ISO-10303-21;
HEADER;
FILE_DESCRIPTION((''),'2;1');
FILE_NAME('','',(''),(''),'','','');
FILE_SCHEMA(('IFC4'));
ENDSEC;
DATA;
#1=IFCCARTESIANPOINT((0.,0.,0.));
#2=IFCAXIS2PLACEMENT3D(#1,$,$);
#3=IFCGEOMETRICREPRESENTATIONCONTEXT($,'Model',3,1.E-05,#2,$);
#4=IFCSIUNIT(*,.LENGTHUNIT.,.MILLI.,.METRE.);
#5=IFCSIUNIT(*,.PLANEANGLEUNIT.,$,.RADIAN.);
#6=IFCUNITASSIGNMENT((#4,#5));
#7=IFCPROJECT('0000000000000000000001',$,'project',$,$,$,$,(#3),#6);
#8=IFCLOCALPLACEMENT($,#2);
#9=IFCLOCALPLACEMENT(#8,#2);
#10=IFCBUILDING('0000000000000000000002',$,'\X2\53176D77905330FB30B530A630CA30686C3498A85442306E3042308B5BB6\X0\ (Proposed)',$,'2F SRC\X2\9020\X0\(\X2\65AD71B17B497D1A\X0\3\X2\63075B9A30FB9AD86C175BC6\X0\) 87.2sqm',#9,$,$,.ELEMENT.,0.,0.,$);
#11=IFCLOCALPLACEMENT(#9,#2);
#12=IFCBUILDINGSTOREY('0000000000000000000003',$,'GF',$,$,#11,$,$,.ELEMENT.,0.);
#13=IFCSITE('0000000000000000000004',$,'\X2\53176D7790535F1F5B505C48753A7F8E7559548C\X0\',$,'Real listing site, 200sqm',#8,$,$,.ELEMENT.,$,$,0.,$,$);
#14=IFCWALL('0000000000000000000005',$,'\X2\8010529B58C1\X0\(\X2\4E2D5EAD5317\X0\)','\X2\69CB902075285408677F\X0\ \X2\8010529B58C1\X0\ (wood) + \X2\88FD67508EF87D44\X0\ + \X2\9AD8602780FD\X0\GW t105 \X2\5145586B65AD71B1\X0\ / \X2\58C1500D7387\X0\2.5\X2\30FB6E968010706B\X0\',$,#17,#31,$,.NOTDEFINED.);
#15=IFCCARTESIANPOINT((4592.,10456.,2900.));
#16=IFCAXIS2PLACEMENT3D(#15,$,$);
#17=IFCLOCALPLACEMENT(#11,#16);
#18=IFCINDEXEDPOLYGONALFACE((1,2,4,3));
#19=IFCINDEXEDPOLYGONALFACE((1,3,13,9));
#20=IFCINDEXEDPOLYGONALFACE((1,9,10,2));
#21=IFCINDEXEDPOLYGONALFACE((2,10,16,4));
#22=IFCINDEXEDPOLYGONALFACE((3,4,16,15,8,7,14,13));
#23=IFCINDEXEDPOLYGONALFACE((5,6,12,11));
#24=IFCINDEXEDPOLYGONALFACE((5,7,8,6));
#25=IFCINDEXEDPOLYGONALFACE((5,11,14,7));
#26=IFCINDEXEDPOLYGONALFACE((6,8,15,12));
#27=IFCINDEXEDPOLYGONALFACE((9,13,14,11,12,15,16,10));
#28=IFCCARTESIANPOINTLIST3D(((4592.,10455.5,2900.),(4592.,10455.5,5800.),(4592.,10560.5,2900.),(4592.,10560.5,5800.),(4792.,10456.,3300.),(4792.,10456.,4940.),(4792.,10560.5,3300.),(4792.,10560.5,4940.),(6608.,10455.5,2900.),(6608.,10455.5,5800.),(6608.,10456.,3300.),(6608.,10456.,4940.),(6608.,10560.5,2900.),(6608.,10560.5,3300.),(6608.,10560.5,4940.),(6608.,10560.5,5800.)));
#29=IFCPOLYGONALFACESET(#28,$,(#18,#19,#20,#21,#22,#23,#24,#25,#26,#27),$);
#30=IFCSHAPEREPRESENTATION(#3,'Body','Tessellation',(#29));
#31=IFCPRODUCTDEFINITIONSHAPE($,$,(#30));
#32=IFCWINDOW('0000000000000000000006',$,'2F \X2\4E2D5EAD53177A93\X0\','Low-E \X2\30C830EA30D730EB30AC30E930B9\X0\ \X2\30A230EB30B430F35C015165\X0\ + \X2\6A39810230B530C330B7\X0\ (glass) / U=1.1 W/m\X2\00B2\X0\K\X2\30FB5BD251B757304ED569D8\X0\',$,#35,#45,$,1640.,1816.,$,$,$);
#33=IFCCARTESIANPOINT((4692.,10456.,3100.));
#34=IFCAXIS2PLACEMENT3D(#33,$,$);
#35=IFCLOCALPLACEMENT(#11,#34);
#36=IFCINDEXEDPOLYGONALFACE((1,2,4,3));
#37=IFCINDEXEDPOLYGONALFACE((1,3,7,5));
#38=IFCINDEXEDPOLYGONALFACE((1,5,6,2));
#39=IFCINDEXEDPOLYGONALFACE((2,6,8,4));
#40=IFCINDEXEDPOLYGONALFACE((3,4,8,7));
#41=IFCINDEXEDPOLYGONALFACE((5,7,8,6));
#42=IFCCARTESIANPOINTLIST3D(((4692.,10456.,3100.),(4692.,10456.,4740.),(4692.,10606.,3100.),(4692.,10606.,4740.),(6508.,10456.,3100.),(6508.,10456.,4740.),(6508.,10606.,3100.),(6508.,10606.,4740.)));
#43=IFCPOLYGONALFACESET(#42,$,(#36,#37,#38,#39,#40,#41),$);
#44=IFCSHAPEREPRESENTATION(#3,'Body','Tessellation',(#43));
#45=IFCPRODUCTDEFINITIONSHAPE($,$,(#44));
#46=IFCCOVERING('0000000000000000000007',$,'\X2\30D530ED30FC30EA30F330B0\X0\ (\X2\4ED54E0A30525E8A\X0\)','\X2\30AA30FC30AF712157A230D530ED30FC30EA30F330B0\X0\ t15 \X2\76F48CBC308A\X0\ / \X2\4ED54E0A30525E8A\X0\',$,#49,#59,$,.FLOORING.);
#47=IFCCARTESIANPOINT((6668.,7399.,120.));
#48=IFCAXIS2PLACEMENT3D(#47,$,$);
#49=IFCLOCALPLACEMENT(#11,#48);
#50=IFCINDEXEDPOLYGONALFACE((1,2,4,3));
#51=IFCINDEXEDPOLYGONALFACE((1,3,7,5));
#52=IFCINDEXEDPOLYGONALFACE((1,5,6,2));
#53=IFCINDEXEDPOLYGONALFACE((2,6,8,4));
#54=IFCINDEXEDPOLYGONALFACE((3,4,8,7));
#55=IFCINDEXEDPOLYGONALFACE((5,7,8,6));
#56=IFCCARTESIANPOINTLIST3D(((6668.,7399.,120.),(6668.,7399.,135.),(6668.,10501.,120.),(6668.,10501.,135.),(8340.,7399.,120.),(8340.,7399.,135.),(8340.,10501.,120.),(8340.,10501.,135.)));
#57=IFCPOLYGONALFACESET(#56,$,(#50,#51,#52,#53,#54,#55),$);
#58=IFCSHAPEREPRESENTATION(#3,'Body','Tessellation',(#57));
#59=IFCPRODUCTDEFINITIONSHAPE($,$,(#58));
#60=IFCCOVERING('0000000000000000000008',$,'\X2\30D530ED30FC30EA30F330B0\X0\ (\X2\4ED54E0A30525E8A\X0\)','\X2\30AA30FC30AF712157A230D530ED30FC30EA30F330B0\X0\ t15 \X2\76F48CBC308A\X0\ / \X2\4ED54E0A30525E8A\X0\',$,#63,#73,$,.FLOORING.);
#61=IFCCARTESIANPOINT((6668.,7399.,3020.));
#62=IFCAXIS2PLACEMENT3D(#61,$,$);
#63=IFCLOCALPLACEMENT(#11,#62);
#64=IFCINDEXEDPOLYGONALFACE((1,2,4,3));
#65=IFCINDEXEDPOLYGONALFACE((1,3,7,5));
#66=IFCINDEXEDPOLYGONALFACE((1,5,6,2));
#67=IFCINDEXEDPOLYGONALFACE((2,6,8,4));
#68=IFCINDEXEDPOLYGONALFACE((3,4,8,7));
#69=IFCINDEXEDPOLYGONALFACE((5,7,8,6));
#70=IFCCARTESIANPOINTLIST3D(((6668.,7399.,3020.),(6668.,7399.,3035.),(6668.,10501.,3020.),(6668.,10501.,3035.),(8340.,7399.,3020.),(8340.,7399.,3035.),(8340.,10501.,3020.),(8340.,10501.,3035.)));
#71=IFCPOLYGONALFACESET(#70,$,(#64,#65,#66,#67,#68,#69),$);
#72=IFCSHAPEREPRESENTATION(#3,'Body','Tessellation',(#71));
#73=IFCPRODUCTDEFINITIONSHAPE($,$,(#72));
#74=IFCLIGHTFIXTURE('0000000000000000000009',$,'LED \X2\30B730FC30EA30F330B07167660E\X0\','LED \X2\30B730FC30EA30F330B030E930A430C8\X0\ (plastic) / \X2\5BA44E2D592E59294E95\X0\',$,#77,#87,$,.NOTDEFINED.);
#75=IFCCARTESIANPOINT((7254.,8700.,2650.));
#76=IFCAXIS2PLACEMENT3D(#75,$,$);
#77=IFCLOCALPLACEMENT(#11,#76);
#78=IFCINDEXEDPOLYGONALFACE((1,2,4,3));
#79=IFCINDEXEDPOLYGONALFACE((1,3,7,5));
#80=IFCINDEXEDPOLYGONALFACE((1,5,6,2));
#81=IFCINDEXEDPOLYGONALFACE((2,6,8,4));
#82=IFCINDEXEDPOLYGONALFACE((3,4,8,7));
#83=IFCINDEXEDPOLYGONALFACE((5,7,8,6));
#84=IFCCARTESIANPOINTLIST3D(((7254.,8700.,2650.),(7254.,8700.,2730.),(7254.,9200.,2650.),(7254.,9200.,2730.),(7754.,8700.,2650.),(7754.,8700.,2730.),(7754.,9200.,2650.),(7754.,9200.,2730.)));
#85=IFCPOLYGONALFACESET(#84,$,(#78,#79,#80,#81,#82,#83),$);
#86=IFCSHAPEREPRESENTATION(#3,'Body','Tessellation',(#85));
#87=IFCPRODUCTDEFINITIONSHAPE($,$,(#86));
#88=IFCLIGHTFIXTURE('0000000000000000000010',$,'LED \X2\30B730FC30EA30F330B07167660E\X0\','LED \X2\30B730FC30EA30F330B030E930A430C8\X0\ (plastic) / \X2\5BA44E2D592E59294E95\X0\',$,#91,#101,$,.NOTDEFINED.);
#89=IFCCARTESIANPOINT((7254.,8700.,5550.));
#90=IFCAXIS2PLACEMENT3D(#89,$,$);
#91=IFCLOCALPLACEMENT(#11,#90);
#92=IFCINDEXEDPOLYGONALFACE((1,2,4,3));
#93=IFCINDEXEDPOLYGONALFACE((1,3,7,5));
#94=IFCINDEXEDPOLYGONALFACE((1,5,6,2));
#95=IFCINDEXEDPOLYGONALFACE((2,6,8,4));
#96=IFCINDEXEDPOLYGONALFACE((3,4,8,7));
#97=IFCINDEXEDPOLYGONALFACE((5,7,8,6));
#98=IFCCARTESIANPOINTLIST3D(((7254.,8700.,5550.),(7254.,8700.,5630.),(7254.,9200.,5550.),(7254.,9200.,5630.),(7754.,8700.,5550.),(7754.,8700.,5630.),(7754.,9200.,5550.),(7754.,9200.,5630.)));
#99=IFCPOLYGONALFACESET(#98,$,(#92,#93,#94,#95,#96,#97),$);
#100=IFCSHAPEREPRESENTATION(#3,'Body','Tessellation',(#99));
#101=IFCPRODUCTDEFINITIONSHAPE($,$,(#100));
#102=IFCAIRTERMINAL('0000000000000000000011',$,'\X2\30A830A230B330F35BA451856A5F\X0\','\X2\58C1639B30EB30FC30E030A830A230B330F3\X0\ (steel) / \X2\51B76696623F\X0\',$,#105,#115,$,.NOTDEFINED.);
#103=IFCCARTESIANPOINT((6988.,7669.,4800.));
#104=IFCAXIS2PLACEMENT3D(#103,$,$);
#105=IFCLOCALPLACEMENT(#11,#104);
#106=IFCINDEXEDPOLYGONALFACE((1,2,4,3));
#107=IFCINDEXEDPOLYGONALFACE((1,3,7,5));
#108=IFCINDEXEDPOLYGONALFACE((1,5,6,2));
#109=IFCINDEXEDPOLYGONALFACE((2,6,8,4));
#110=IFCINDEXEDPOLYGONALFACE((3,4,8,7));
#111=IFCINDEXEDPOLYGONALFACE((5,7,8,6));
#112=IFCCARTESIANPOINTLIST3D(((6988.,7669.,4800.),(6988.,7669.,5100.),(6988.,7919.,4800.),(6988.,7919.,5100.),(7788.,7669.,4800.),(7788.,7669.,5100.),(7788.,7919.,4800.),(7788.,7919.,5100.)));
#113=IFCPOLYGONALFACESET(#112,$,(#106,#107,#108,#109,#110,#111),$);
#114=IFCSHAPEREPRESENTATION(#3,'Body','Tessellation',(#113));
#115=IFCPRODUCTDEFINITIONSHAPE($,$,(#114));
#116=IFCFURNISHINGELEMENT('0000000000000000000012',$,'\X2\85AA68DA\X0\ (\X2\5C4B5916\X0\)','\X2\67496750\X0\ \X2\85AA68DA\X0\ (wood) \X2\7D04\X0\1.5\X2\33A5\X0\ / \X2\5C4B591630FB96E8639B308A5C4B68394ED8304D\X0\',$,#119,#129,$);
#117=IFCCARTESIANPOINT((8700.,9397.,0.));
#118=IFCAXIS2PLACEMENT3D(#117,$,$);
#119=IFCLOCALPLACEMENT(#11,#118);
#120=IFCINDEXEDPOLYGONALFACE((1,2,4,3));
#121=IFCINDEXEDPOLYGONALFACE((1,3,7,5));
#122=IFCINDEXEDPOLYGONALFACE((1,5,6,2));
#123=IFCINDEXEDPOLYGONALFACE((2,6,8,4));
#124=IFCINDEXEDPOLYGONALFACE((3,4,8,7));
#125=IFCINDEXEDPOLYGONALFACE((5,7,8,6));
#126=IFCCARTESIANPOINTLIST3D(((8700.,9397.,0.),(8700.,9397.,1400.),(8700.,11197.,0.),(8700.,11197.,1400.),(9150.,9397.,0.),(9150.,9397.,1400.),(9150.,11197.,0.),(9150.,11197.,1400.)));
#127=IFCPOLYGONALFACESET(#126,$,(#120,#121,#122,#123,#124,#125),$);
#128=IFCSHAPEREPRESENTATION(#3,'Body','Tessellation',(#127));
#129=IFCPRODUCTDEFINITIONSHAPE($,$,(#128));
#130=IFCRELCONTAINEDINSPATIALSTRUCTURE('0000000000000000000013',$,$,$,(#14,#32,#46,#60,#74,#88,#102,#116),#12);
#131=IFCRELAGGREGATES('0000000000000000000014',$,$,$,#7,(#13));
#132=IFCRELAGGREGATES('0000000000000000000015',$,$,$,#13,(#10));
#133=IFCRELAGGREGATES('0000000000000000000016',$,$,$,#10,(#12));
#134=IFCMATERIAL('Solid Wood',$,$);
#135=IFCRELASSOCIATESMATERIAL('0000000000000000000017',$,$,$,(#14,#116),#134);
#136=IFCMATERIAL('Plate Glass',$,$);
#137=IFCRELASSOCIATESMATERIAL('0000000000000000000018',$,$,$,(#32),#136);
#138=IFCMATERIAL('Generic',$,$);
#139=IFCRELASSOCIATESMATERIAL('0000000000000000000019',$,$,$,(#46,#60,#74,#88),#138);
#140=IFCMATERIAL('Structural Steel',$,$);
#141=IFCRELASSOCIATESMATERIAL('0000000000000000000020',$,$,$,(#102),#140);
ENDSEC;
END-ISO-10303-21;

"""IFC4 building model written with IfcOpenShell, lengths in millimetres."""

from ifc_helpers import new_model, si_unit, frame, frame_2d, origin, place, context, project, spatial, rectangle, extrude, material, element, fill, save


model = new_model("IFC4")

# Units and contexts
model_context = context("Model", 3, precision=1e-05, world=origin())
ifc_project = project(units=[si_unit("LENGTHUNIT", "METRE", prefix="MILLI"), si_unit("PLANEANGLEUNIT", "RADIAN")], contexts=[model_context])

# Site, building, storey
site_placement = place(None, origin())
site = spatial("IfcSite", under=ifc_project, at=site_placement, Name="北海道弟子屈町美留和", ObjectType="Real listing site, 200sqm", CompositionType="ELEMENT", RefElevation=0.0)
building_placement = place(site_placement, origin())
building = spatial("IfcBuilding", under=site, at=building_placement, Name="北海道・サウナと水風呂のある家 (Proposed)", ObjectType="2F SRC造(断熱等級3指定・高気密) 87.2sqm", CompositionType="ELEMENT", ElevationOfRefHeight=0.0, ElevationOfTerrain=0.0)
storey_placement = place(building_placement, origin())
storey = spatial("IfcBuildingStorey", under=building, at=storey_placement, Name="GF", CompositionType="ELEMENT", Elevation=0.0)

# Shared definitions
ifc_material_1 = material(Name="Solid Wood")

# Wall, opening, window
ifc_material_2 = material(Name="Plate Glass")
wall_1_placement = place(storey_placement, frame((4592.0, 10456.0, 2900.0)))
wall_1 = element("IfcWall", 1, at=wall_1_placement, inside=storey, material=ifc_material_1, Name="耐力壁(中庭北)", Description="構造用合板 耐力壁 (wood) + 製材軸組 + 高性能GW t105 充填断熱 / 壁倍率2.5・準耐火", PredefinedType="NOTDEFINED", context=model_context, shape_type="SweptSolid", body=[
    extrude(rectangle(XDim=2016.0, YDim=105.0, at=frame_2d((1008.0, 52.0))), frame((4592.0, 10456.0, 2900.0)), (0.0, 0.0, 1.0), 2900.0),
])
opening_1_placement = place(storey_placement, frame((4692.0, 10456.0, 3100.0)))
opening_1 = element("IfcOpeningElement", 2, at=opening_1_placement, cuts=wall_1, PredefinedType="NOTDEFINED", context=model_context, shape_type="SweptSolid", body=[
    extrude(rectangle(XDim=1816.0, YDim=150.0, at=frame_2d((908.0, 75.0))), frame((4692.0, 10456.0, 3100.0)), (0.0, 0.0, 1.0), 1640.0),
])
window_1_placement = place(storey_placement, frame((4692.0, 10456.0, 3100.0)))
window_1 = element("IfcWindow", 3, at=window_1_placement, inside=storey, material=ifc_material_2, Name="2F 中庭北窓", Description="Low-E トリプルガラス アルゴン封入 + 樹脂サッシ (glass) / U=1.1 W/m²K・寒冷地仕様", OverallHeight=1640.0, OverallWidth=1816.0, context=model_context, shape_type="SweptSolid", body=[
    extrude(rectangle(XDim=1816.0, YDim=150.0, at=frame_2d((908.0, 75.0))), frame((4692.0, 10456.0, 3100.0)), (0.0, 0.0, 1.0), 1640.0),
])
fill(opening_1, window_1)

# Coverings
ifc_material_3 = material(Name="Generic")
covering_1_placement = place(storey_placement, frame((6668.0, 7399.0, 120.0)))
element("IfcCovering", 4, at=covering_1_placement, inside=storey, material=ifc_material_3, Name="フローリング (仕上げ床)", Description="オーク無垢フローリング t15 直貼り / 仕上げ床", PredefinedType="FLOORING", context=model_context, shape_type="SweptSolid", body=[
    extrude(rectangle(XDim=1672.0, YDim=3102.0, at=frame_2d((836.0, 1551.0))), frame((6668.0, 7399.0, 120.0)), (0.0, 0.0, 1.0), 15.0),
])
covering_2_placement = place(storey_placement, frame((6668.0, 7399.0, 3020.0)))
element("IfcCovering", 5, at=covering_2_placement, inside=storey, material=ifc_material_3, Name="フローリング (仕上げ床)", Description="オーク無垢フローリング t15 直貼り / 仕上げ床", PredefinedType="FLOORING", context=model_context, shape_type="SweptSolid", body=[
    extrude(rectangle(XDim=1672.0, YDim=3102.0, at=frame_2d((836.0, 1551.0))), frame((6668.0, 7399.0, 3020.0)), (0.0, 0.0, 1.0), 15.0),
])

# Light fixtures
light_fixture_1_placement = place(storey_placement, frame((7254.0, 8700.0, 2650.0)))
element("IfcLightFixture", 6, at=light_fixture_1_placement, inside=storey, material=ifc_material_3, Name="LED シーリング照明", Description="LED シーリングライト (plastic) / 室中央天井", PredefinedType="NOTDEFINED", context=model_context, shape_type="SweptSolid", body=[
    extrude(rectangle(XDim=500.0, YDim=500.0, at=frame_2d((250.0, 250.0))), frame((7254.0, 8700.0, 2650.0)), (0.0, 0.0, 1.0), 80.0),
])
light_fixture_2_placement = place(storey_placement, frame((7254.0, 8700.0, 5550.0)))
element("IfcLightFixture", 7, at=light_fixture_2_placement, inside=storey, material=ifc_material_3, Name="LED シーリング照明", Description="LED シーリングライト (plastic) / 室中央天井", PredefinedType="NOTDEFINED", context=model_context, shape_type="SweptSolid", body=[
    extrude(rectangle(XDim=500.0, YDim=500.0, at=frame_2d((250.0, 250.0))), frame((7254.0, 8700.0, 5550.0)), (0.0, 0.0, 1.0), 80.0),
])

# Air terminal
ifc_material_4 = material(Name="Structural Steel")
air_terminal_placement = place(storey_placement, frame((6988.0, 7669.0, 4800.0)))
element("IfcAirTerminal", 8, at=air_terminal_placement, inside=storey, material=ifc_material_4, Name="エアコン室内機", Description="壁掛ルームエアコン (steel) / 冷暖房", PredefinedType="NOTDEFINED", context=model_context, shape_type="SweptSolid", body=[
    extrude(rectangle(XDim=800.0, YDim=250.0, at=frame_2d((400.0, 125.0))), frame((6988.0, 7669.0, 4800.0)), (0.0, 0.0, 1.0), 300.0),
])

# Furnishing element
furnishing_placement = place(storey_placement, frame((8700.0, 9397.0, 0.0)))
element("IfcFurnishingElement", 9, at=furnishing_placement, inside=storey, material=ifc_material_1, Name="薪棚 (屋外)", Description="杉材 薪棚 (wood) 約1.5㎥ / 屋外・雨掛り屋根付き", context=model_context, shape_type="SweptSolid", body=[
    extrude(rectangle(XDim=450.0, YDim=1800.0, at=frame_2d((225.0, 900.0))), frame((8700.0, 9397.0, 0.0)), (0.0, 0.0, 1.0), 1400.0),
])

save(model, "model.ifc")
